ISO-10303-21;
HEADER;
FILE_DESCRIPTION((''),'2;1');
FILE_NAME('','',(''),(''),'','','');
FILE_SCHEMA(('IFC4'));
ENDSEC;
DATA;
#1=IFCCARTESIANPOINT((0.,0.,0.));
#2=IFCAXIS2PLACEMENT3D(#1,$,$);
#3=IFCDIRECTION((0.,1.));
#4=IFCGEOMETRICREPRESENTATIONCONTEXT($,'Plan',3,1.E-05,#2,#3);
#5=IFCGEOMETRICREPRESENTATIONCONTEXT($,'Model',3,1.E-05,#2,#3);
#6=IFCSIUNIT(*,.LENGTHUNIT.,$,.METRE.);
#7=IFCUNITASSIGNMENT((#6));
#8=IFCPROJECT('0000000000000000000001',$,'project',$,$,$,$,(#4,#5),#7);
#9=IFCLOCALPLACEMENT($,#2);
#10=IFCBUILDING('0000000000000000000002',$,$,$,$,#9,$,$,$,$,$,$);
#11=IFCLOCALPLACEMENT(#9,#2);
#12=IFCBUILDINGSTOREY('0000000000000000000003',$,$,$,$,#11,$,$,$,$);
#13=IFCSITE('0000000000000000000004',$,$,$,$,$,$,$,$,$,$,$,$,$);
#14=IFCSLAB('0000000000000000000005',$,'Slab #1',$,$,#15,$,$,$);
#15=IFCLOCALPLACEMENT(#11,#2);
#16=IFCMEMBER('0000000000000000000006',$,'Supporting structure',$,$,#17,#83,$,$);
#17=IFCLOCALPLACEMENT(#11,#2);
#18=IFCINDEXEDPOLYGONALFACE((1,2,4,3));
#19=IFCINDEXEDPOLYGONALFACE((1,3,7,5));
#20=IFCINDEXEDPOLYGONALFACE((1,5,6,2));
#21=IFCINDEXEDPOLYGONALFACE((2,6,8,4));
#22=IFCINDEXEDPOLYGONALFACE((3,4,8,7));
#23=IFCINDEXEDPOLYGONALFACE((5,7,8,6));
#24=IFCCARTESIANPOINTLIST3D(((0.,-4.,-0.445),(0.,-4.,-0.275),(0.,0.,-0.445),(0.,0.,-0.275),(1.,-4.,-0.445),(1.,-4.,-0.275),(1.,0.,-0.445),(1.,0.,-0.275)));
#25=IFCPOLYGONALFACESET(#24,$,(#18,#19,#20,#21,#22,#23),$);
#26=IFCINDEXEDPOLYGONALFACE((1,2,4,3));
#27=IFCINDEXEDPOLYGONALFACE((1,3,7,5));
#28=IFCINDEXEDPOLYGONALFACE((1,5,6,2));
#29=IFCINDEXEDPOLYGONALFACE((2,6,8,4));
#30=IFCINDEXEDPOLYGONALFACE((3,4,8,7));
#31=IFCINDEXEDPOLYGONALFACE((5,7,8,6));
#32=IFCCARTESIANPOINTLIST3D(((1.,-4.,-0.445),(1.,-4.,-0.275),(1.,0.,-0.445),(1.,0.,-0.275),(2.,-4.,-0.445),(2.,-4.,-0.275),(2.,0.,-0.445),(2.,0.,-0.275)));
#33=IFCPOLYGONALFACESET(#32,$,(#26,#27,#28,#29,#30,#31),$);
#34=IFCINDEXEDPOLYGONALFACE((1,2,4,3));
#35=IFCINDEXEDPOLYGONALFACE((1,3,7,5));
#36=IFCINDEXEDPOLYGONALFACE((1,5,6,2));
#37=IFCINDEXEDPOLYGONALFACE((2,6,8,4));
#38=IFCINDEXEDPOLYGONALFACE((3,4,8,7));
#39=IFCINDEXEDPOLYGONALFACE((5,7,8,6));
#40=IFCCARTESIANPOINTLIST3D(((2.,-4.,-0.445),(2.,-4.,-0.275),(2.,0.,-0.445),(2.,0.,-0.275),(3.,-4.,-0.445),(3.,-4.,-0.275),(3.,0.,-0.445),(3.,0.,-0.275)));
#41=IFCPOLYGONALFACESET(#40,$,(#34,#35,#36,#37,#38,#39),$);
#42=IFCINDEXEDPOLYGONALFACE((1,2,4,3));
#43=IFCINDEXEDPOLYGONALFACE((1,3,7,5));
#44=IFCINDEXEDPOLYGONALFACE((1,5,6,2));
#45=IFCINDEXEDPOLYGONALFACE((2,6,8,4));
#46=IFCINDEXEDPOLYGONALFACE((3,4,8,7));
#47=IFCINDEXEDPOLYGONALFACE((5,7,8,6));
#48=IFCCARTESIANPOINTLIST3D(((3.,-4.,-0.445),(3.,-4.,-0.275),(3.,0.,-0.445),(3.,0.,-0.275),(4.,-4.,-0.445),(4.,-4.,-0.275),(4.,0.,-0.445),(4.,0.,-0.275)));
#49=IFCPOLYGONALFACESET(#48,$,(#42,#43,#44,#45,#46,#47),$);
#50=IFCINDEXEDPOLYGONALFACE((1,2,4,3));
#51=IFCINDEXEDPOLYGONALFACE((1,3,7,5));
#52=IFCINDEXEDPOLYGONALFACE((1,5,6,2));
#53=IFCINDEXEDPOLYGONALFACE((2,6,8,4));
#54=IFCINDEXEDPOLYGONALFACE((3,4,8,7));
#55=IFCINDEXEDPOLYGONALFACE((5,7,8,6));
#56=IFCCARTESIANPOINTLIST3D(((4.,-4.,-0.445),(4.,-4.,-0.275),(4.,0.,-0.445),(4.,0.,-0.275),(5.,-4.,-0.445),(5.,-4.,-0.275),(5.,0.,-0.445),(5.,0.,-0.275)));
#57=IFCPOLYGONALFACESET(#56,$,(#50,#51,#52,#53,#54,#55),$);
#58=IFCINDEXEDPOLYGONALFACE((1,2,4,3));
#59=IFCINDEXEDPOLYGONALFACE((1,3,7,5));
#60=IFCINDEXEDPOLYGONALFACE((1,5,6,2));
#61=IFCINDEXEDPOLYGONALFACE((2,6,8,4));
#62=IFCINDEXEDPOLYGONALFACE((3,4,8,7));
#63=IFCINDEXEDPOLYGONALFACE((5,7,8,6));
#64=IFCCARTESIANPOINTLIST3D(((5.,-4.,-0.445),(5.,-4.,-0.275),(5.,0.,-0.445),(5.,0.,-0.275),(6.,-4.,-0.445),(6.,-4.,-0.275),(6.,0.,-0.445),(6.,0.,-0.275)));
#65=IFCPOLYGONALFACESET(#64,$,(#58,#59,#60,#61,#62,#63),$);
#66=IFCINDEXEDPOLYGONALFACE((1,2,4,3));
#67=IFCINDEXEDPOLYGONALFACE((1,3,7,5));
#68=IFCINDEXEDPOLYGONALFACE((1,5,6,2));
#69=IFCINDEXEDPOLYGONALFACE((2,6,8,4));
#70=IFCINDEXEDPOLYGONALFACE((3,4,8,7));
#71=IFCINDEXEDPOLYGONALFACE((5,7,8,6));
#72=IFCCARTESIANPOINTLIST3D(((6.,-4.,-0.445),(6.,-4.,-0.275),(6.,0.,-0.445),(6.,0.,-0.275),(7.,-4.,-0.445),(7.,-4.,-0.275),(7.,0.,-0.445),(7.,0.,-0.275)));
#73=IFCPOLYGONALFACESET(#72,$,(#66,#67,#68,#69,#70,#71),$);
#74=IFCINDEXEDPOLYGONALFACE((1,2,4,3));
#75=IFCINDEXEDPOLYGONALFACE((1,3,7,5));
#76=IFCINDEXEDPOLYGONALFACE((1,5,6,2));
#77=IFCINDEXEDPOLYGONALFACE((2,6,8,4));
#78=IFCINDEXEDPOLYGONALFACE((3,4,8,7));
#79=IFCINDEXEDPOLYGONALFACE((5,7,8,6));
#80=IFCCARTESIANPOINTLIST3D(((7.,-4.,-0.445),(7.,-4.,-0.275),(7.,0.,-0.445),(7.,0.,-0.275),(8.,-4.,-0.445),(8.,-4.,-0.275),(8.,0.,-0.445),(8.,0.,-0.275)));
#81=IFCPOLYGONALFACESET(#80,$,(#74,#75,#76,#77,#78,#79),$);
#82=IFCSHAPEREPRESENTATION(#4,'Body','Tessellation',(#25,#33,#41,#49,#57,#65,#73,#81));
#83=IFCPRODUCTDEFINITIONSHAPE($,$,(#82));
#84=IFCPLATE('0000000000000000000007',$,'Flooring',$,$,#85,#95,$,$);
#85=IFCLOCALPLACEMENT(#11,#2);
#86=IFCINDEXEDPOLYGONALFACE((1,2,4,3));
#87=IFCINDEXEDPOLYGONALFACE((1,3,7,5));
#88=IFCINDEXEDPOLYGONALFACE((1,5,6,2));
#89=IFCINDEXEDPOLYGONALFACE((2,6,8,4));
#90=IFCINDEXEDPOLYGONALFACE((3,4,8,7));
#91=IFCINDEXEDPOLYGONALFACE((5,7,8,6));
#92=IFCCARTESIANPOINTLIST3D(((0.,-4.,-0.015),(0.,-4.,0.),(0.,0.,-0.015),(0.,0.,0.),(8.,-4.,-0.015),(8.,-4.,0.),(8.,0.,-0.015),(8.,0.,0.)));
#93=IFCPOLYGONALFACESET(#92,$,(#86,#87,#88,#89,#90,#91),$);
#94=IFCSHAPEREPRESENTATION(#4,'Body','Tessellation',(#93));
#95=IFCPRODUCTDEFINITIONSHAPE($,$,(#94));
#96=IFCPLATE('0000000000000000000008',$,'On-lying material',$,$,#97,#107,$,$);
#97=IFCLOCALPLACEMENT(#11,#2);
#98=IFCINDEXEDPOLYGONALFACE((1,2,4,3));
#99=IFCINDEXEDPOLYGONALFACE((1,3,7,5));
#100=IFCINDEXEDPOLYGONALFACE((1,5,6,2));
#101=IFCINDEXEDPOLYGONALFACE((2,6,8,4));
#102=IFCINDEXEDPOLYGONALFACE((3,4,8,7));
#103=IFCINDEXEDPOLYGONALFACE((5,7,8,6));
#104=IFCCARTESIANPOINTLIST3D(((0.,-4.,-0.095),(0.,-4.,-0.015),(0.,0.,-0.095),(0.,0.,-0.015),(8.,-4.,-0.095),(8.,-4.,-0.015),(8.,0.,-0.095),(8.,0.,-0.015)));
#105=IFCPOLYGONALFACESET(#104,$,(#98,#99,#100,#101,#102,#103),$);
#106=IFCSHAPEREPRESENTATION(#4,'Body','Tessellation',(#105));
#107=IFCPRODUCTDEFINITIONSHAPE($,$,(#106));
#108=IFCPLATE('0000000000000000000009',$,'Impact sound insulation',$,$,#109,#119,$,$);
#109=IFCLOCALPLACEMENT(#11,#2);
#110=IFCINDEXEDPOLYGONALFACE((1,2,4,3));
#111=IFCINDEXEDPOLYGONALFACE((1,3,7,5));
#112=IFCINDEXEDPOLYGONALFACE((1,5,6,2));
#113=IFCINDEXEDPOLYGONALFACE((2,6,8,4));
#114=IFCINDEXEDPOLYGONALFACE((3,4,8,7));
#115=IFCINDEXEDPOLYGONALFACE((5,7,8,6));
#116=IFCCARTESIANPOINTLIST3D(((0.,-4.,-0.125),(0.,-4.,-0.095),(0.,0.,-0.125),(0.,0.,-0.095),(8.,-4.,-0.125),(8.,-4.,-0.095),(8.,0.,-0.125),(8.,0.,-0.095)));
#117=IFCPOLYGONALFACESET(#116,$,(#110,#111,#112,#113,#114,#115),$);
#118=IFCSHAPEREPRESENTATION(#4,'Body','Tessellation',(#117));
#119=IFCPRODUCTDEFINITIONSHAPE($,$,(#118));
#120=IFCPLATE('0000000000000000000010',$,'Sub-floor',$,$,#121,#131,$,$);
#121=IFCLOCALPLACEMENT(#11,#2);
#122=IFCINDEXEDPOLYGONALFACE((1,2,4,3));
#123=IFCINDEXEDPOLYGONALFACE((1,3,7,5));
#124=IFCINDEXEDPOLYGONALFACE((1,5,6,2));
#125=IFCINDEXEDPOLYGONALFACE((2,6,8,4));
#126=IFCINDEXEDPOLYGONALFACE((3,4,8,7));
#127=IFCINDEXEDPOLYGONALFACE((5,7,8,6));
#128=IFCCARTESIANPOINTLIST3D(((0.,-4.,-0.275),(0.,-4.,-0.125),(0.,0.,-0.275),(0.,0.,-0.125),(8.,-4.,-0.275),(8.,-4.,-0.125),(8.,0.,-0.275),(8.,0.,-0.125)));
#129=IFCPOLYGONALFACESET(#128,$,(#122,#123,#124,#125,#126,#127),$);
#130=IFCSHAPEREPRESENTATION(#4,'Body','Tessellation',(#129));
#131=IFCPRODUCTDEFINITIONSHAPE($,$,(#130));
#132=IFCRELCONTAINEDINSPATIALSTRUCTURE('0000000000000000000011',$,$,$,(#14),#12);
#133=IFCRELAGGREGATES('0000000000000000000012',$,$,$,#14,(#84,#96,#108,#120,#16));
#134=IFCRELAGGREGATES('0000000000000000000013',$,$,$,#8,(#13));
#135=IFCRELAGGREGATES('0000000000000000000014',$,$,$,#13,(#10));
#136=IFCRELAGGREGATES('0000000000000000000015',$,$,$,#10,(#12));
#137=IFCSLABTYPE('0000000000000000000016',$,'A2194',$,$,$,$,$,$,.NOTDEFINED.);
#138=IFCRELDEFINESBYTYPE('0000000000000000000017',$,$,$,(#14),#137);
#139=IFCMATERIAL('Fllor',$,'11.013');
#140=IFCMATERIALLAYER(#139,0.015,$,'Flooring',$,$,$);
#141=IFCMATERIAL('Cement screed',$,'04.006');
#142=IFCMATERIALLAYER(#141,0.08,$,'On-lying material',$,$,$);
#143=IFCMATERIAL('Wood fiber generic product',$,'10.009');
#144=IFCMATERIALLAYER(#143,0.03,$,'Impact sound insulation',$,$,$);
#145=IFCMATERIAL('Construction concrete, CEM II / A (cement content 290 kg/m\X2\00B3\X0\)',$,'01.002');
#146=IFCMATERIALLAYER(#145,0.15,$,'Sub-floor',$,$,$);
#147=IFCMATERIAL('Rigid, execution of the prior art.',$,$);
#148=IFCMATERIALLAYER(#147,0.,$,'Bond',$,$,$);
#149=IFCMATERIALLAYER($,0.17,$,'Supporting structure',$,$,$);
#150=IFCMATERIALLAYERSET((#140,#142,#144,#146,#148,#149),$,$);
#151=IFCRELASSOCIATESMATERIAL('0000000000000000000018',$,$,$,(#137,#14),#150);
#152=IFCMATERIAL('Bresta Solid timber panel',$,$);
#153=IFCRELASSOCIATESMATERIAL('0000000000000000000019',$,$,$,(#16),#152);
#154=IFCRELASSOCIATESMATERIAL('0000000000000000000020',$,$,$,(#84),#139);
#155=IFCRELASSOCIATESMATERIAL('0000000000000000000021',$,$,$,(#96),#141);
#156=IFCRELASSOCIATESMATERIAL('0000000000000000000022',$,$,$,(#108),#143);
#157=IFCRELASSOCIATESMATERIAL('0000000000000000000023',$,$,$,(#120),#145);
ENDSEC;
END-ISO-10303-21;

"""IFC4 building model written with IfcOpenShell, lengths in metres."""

from ifc_helpers import new_model, si_unit, direction, frame, frame_2d, origin, origin_with_axes, place, context, project, spatial, rectangle, extrude, material, layer, layer_set, type_object, element, aggregate, save


model = new_model("IFC4")

# Units and contexts
plan_context = context("Plan", 3, precision=1e-05, world=origin(), true_north=direction((0.0, 1.0)))
model_context = context("Model", 3, precision=1e-05, world=origin(), true_north=direction((0.0, 1.0)))
ifc_project = project(units=[si_unit("LENGTHUNIT", "METRE")], contexts=[plan_context, model_context])

# Site, building, storey
site = spatial("IfcSite", under=ifc_project)
building_placement = place(None, origin())
building = spatial("IfcBuilding", under=site, at=building_placement)
storey_placement = place(building_placement, origin())
storey = spatial("IfcBuildingStorey", under=building, at=storey_placement)

# Slab, member, plates
ifc_material_1 = material(Name="Fllor", Category="11.013")
ifc_layer_1 = layer(ifc_material_1, 0.015, Name="Flooring")
ifc_material_2 = material(Name="Cement screed", Category="04.006")
ifc_layer_2 = layer(ifc_material_2, 0.08, Name="On-lying material")
ifc_material_3 = material(Name="Wood fiber generic product", Category="10.009")
ifc_layer_3 = layer(ifc_material_3, 0.03, Name="Impact sound insulation")
ifc_material_4 = material(Name="Construction concrete, CEM II / A (cement content 290 kg/m³)", Category="01.002")
ifc_layer_4 = layer(ifc_material_4, 0.15, Name="Sub-floor")
ifc_material_5 = material(Name="Rigid, execution of the prior art.")
ifc_layer_5 = layer(ifc_material_5, 0.0, Name="Bond")
ifc_layer_6 = layer(None, 0.17, Name="Supporting structure")
ifc_layer_set = layer_set([ifc_layer_1, ifc_layer_2, ifc_layer_3, ifc_layer_4, ifc_layer_5, ifc_layer_6])
slab_type = type_object("IfcSlabType", Name="A2194", PredefinedType="NOTDEFINED", material=ifc_layer_set)
slab_placement = place(None, frame((0.0, 0.0, 0.0), z_axis=(0.0, 0.0, -1.0), x_axis=(1.0, 0.0, 0.0)))
slab = element("IfcSlab", 1, at=slab_placement, inside=storey, type_object=slab_type, material=ifc_layer_set, Name="Slab #1")
ifc_material_6 = material(Name="Bresta Solid timber panel")
member_placement = place(slab_placement, origin())
member = element("IfcMember", 2, at=member_placement, material=ifc_material_6, Name="Supporting structure", context=plan_context, shape_type="SweptSolid", body=[
    extrude(rectangle(XDim=1.0, YDim=0.17, at=frame_2d((0.5, 0.085), x_axis=(1.0, 0.0))), frame((0.0, 4.0, 0.275), z_axis=(0.0, -1.0, 0.0), x_axis=(1.0, 0.0, 0.0)), (0.0, 0.0, 1.0), 4.0),
    extrude(rectangle(XDim=1.0, YDim=0.17, at=frame_2d((0.5, 0.085), x_axis=(1.0, 0.0))), frame((1.0, 4.0, 0.275), z_axis=(0.0, -1.0, 0.0), x_axis=(1.0, 0.0, 0.0)), (0.0, 0.0, 1.0), 4.0),
    extrude(rectangle(XDim=1.0, YDim=0.17, at=frame_2d((0.5, 0.085), x_axis=(1.0, 0.0))), frame((2.0, 4.0, 0.275), z_axis=(0.0, -1.0, 0.0), x_axis=(1.0, 0.0, 0.0)), (0.0, 0.0, 1.0), 4.0),
    extrude(rectangle(XDim=1.0, YDim=0.17, at=frame_2d((0.5, 0.085), x_axis=(1.0, 0.0))), frame((3.0, 4.0, 0.275), z_axis=(0.0, -1.0, 0.0), x_axis=(1.0, 0.0, 0.0)), (0.0, 0.0, 1.0), 4.0),
    extrude(rectangle(XDim=1.0, YDim=0.17, at=frame_2d((0.5, 0.085), x_axis=(1.0, 0.0))), frame((4.0, 4.0, 0.275), z_axis=(0.0, -1.0, 0.0), x_axis=(1.0, 0.0, 0.0)), (0.0, 0.0, 1.0), 4.0),
    extrude(rectangle(XDim=1.0, YDim=0.17, at=frame_2d((0.5, 0.085), x_axis=(1.0, 0.0))), frame((5.0, 4.0, 0.275), z_axis=(0.0, -1.0, 0.0), x_axis=(1.0, 0.0, 0.0)), (0.0, 0.0, 1.0), 4.0),
    extrude(rectangle(XDim=1.0, YDim=0.17, at=frame_2d((0.5, 0.085), x_axis=(1.0, 0.0))), frame((6.0, 4.0, 0.275), z_axis=(0.0, -1.0, 0.0), x_axis=(1.0, 0.0, 0.0)), (0.0, 0.0, 1.0), 4.0),
    extrude(rectangle(XDim=1.0, YDim=0.17, at=frame_2d((0.5, 0.085), x_axis=(1.0, 0.0))), frame((7.0, 4.0, 0.275), z_axis=(0.0, -1.0, 0.0), x_axis=(1.0, 0.0, 0.0)), (0.0, 0.0, 1.0), 4.0),
])
plate_1_placement = place(slab_placement, origin())
plate_1 = element("IfcPlate", 3, at=plate_1_placement, material=ifc_material_1, Name="Flooring", context=plan_context, shape_type="SweptSolid", body=[
    extrude(rectangle(XDim=8.0, YDim=4.0, at=frame_2d((4.0, 2.0), x_axis=(1.0, 0.0))), origin_with_axes(), (0.0, 0.0, 1.0), 0.015),
])
plate_2_placement = place(slab_placement, origin())
plate_2 = element("IfcPlate", 4, at=plate_2_placement, material=ifc_material_2, Name="On-lying material", context=plan_context, shape_type="SweptSolid", body=[
    extrude(rectangle(XDim=8.0, YDim=4.0, at=frame_2d((4.0, 2.0), x_axis=(1.0, 0.0))), frame((0.0, 0.0, 0.015), z_axis=(0.0, 0.0, 1.0), x_axis=(1.0, 0.0, 0.0)), (0.0, 0.0, 1.0), 0.08),
])
plate_3_placement = place(slab_placement, origin())
plate_3 = element("IfcPlate", 5, at=plate_3_placement, material=ifc_material_3, Name="Impact sound insulation", context=plan_context, shape_type="SweptSolid", body=[
    extrude(rectangle(XDim=8.0, YDim=4.0, at=frame_2d((4.0, 2.0), x_axis=(1.0, 0.0))), frame((0.0, 0.0, 0.095), z_axis=(0.0, 0.0, 1.0), x_axis=(1.0, 0.0, 0.0)), (0.0, 0.0, 1.0), 0.03),
])
plate_4_placement = place(slab_placement, origin())
plate_4 = element("IfcPlate", 6, at=plate_4_placement, material=ifc_material_4, Name="Sub-floor", context=plan_context, shape_type="SweptSolid", body=[
    extrude(rectangle(XDim=8.0, YDim=4.0, at=frame_2d((4.0, 2.0), x_axis=(1.0, 0.0))), frame((0.0, 0.0, 0.125), z_axis=(0.0, 0.0, 1.0), x_axis=(1.0, 0.0, 0.0)), (0.0, 0.0, 1.0), 0.15),
])
aggregate(slab, [plate_1, plate_2, plate_3, plate_4, member])

save(model, "model.ifc")
